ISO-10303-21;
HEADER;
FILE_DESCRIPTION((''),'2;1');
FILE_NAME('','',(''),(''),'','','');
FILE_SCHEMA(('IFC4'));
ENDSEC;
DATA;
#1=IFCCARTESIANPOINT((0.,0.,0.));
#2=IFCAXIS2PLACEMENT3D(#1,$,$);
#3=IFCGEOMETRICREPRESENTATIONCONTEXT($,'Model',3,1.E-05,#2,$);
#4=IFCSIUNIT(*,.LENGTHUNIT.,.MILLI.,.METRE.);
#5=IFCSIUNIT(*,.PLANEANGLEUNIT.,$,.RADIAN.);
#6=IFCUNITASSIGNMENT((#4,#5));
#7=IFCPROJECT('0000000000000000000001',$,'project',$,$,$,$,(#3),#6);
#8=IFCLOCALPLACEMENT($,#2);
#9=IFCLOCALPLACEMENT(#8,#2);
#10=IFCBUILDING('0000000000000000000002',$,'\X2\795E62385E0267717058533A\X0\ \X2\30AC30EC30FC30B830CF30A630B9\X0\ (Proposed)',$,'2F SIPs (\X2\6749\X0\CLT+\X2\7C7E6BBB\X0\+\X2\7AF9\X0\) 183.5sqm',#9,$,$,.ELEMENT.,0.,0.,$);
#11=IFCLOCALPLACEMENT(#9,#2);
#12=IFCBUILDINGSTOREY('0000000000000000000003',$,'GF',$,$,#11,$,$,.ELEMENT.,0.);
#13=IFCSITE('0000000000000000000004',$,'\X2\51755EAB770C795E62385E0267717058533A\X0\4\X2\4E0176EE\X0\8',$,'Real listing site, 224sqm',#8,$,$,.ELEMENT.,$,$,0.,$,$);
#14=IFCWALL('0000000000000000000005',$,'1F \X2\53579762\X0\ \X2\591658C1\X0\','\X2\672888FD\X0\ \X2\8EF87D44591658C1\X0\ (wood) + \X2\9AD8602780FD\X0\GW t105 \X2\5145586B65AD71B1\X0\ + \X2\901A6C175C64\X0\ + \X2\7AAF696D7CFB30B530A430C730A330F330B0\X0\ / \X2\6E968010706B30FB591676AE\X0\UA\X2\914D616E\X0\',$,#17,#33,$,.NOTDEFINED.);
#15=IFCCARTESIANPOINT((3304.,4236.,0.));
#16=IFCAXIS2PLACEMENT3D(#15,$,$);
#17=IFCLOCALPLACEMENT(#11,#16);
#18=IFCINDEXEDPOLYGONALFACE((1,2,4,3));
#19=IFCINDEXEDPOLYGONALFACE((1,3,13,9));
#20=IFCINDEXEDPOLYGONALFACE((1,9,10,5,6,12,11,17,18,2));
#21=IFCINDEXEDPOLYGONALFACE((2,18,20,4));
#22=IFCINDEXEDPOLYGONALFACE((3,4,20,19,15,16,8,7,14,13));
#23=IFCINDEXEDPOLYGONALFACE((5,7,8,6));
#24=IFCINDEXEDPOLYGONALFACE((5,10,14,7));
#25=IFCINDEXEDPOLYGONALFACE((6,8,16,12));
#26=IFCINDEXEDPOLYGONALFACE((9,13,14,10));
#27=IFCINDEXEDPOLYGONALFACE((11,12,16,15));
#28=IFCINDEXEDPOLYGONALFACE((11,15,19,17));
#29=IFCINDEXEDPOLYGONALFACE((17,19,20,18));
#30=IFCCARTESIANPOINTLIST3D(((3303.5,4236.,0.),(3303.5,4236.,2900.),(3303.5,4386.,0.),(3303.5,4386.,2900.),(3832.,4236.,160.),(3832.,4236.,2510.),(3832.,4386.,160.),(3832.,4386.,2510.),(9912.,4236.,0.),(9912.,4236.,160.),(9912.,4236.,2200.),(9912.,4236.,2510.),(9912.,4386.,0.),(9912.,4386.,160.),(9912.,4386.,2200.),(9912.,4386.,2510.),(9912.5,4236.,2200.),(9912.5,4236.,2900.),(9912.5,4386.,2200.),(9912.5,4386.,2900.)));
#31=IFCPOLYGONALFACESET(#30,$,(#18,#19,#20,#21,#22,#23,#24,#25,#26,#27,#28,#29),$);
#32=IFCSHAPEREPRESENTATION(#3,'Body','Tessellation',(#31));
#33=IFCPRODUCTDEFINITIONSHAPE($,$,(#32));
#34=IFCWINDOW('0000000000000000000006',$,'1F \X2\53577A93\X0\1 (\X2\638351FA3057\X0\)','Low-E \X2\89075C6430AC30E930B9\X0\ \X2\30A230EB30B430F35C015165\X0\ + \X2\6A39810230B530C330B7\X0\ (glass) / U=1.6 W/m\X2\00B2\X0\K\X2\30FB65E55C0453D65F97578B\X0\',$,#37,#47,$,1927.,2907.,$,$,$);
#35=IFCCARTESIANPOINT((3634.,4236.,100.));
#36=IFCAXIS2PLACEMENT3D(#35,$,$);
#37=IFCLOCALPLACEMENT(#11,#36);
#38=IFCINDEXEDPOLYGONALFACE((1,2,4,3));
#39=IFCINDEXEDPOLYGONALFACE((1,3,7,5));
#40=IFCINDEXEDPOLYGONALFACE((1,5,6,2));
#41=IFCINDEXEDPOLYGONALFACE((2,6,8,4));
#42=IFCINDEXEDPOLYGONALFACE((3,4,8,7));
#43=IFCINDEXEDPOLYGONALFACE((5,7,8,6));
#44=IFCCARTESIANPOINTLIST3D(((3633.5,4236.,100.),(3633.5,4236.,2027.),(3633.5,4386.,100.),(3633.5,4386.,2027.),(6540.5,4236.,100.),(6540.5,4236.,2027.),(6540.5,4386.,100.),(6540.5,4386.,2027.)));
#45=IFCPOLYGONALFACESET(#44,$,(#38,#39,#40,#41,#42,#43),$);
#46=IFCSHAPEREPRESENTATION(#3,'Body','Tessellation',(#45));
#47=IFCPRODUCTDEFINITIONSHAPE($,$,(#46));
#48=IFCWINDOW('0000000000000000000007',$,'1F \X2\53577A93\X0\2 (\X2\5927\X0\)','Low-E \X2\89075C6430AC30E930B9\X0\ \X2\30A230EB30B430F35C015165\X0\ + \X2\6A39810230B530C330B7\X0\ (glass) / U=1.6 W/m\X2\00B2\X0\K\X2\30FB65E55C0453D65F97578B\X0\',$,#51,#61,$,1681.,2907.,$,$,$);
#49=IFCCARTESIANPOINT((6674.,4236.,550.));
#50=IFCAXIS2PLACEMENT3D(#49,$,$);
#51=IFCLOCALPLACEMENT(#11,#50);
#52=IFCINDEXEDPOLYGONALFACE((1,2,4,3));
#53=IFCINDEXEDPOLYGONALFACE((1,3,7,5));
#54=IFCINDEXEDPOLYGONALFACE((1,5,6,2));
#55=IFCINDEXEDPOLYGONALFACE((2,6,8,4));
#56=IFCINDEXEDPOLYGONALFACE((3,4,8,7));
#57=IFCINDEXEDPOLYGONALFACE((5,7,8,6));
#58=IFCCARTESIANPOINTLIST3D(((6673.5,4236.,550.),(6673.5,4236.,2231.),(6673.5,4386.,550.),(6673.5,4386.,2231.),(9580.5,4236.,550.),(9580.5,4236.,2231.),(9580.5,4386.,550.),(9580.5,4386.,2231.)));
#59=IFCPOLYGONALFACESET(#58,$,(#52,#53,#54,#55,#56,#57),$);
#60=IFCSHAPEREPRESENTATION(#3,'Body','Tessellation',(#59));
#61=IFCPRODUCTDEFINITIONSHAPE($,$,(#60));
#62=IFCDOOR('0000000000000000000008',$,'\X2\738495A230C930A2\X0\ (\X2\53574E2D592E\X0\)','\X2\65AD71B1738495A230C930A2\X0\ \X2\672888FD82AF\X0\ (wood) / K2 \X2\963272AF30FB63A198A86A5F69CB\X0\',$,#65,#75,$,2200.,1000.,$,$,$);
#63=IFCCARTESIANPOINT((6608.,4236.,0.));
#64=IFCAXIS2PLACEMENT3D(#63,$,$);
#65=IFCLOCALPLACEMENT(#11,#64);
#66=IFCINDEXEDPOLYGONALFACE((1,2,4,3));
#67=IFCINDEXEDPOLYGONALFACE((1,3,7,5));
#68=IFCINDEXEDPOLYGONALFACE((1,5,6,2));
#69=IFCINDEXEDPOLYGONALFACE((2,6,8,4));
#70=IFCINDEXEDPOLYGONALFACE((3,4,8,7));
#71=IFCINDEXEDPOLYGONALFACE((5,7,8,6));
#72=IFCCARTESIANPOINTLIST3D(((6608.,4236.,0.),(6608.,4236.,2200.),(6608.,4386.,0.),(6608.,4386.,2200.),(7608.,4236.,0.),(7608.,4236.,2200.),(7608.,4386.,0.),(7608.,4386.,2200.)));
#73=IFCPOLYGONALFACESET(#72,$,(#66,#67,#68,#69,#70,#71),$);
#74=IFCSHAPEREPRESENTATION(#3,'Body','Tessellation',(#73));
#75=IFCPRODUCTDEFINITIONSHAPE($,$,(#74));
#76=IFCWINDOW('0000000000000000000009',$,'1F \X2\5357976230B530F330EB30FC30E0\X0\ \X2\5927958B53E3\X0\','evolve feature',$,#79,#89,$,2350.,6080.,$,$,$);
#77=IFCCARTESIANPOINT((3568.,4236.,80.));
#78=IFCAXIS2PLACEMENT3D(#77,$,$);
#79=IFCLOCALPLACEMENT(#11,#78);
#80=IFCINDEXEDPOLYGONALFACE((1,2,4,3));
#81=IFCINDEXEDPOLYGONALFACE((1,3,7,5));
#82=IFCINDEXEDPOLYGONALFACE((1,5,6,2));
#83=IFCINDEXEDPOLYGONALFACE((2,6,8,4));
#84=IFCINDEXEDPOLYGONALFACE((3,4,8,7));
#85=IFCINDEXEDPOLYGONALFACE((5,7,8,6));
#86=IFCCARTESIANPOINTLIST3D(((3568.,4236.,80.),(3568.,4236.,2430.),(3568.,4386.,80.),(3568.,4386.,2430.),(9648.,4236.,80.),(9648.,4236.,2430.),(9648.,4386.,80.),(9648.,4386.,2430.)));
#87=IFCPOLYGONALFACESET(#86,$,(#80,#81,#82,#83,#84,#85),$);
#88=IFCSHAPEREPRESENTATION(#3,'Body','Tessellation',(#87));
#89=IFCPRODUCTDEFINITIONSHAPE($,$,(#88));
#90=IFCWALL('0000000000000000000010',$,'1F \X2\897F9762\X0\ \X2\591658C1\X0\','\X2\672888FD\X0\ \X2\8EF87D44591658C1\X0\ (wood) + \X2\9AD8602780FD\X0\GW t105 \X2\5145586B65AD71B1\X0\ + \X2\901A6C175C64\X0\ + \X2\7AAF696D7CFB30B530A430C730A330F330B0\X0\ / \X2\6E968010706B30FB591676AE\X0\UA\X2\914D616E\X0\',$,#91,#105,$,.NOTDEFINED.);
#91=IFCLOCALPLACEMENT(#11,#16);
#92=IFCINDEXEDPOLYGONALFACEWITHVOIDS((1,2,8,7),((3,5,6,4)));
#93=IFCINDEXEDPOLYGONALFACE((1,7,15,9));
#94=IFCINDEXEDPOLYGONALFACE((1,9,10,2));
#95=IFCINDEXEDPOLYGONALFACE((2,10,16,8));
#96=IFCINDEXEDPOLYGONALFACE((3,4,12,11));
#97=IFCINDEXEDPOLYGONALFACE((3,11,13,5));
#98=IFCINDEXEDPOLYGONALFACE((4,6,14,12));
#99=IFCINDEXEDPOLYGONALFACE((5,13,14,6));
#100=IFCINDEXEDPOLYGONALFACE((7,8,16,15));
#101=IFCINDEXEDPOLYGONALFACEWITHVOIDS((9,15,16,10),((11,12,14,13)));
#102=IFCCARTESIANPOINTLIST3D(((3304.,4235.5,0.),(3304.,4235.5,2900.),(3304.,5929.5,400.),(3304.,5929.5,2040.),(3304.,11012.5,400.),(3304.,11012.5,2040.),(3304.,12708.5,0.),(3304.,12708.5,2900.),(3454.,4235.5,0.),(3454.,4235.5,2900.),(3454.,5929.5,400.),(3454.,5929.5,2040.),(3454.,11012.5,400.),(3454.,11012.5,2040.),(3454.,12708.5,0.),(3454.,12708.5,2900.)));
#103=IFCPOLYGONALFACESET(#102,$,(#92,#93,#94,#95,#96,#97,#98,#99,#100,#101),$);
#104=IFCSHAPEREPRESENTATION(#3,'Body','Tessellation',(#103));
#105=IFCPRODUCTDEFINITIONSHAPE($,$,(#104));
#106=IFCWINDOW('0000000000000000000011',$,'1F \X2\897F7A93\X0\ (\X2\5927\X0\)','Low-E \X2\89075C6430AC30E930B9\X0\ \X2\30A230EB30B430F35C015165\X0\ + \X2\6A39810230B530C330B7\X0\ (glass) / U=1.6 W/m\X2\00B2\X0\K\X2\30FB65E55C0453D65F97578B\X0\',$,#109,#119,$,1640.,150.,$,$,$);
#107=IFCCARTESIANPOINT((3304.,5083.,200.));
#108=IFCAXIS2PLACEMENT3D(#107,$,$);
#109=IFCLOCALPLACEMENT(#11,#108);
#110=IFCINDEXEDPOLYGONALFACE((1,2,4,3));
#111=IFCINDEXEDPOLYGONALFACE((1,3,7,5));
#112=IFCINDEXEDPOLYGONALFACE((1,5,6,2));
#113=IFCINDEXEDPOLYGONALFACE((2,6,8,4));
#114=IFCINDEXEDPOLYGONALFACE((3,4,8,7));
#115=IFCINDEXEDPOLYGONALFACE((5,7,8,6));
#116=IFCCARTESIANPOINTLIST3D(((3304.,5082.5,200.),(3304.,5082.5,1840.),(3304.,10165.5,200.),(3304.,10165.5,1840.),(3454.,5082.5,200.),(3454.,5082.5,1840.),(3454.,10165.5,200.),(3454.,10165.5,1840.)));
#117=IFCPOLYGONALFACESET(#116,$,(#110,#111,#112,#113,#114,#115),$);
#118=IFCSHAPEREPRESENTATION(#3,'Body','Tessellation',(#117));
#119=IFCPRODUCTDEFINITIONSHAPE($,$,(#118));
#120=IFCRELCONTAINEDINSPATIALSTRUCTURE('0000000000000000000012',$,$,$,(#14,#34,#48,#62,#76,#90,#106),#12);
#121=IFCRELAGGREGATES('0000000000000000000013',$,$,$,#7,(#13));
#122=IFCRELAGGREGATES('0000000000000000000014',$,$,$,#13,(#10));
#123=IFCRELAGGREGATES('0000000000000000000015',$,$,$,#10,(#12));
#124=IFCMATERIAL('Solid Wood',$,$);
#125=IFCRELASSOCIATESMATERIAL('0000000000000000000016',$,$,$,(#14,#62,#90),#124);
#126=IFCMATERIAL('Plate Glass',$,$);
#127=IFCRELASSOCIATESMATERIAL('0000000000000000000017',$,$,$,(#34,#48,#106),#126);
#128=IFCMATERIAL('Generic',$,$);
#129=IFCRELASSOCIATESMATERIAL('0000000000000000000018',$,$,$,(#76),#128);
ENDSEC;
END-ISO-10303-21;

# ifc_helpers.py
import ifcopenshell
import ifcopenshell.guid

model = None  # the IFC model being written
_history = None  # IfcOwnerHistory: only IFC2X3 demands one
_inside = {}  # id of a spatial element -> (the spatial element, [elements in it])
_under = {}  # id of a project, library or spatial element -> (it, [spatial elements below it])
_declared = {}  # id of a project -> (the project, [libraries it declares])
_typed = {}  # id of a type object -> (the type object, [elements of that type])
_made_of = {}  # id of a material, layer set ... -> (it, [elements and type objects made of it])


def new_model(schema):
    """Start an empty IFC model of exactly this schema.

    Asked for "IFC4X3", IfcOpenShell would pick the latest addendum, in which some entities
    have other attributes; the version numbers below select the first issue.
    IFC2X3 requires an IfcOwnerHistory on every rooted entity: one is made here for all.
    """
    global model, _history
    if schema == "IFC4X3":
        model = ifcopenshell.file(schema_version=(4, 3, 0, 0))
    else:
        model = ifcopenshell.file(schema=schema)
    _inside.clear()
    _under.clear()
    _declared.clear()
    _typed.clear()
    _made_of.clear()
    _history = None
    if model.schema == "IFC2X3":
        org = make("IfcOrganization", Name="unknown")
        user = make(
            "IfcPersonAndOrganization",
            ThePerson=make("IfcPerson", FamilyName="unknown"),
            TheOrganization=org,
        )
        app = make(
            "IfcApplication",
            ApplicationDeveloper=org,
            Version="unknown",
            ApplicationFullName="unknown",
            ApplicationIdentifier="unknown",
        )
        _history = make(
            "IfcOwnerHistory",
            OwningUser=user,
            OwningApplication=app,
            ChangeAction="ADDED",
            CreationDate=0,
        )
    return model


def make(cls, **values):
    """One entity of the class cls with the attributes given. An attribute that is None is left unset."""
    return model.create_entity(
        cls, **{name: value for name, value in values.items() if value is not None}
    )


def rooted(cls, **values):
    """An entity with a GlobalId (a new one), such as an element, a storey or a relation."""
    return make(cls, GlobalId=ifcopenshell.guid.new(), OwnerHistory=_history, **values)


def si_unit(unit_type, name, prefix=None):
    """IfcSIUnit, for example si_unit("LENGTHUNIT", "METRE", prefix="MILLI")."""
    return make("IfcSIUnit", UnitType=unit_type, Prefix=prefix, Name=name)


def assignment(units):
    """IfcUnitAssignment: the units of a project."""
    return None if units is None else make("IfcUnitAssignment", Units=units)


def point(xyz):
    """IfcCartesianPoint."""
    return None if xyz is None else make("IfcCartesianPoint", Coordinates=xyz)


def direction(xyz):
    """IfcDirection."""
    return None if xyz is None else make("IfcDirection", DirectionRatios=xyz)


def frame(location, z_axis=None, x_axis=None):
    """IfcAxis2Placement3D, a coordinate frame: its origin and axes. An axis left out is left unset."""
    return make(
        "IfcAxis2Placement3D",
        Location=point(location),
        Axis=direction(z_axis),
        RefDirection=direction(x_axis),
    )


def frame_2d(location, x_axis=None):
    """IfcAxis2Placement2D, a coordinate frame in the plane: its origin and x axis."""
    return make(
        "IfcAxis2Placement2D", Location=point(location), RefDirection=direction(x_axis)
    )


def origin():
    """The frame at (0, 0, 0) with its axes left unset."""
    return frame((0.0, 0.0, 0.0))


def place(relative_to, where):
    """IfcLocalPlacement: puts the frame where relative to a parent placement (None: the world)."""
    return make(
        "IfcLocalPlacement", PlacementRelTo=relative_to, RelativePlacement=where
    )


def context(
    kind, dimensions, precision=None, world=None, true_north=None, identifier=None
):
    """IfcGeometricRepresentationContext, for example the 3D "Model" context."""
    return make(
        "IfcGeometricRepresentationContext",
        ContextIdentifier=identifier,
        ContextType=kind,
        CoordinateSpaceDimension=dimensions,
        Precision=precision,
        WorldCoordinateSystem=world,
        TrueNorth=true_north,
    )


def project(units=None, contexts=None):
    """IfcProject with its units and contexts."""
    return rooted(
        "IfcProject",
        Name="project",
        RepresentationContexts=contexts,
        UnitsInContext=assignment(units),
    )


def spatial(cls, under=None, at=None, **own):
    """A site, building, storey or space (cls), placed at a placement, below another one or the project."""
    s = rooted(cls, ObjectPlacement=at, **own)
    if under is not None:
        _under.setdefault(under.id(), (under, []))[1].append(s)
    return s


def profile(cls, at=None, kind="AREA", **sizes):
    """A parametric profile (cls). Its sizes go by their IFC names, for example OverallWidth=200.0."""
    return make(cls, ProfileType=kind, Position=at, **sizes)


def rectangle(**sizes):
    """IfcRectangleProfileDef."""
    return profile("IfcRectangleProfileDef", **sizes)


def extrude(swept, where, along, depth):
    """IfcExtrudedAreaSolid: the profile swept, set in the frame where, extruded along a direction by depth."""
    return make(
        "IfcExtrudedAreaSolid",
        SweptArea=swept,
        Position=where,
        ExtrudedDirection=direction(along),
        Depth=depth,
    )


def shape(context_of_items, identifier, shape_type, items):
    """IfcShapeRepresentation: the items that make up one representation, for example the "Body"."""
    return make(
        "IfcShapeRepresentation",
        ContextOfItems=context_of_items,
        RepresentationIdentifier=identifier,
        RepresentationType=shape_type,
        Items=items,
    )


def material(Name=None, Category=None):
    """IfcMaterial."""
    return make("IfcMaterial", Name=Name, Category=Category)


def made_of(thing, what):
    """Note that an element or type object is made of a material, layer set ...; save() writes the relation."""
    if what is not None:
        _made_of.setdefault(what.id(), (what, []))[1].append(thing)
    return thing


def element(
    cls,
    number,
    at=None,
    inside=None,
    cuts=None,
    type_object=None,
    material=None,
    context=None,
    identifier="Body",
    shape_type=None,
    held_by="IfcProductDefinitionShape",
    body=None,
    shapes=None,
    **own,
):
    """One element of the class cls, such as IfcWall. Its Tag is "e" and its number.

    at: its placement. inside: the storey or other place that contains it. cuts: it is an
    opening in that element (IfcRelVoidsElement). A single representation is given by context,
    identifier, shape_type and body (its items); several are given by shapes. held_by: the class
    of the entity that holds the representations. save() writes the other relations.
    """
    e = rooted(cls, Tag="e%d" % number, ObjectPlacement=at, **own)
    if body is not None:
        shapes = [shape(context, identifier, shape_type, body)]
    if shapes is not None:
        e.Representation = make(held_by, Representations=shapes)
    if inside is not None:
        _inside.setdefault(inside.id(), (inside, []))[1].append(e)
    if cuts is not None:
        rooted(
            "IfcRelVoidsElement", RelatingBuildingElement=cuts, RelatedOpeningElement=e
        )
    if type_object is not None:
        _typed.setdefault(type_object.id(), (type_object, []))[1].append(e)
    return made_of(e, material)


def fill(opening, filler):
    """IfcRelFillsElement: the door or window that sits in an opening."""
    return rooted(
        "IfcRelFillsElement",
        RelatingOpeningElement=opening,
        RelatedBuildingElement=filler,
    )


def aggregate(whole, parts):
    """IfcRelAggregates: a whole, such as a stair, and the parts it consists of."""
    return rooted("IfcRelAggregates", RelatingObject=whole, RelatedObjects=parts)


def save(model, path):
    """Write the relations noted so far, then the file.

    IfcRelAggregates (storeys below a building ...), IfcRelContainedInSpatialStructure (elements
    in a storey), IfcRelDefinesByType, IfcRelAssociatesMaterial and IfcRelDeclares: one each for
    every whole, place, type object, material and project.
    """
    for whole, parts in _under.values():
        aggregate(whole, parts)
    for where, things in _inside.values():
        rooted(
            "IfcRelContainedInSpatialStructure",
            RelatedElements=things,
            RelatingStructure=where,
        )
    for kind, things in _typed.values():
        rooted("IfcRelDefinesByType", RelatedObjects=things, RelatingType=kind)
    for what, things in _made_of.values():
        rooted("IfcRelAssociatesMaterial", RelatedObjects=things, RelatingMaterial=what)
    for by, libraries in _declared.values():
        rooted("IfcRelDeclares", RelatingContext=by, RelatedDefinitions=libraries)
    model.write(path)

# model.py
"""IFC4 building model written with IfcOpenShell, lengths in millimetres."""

from ifc_helpers import new_model, si_unit, frame, frame_2d, origin, place, context, project, spatial, rectangle, extrude, material, element, fill, save


model = new_model("IFC4")

# Units and contexts
model_context = context("Model", 3, precision=1e-05, world=origin())
ifc_project = project(units=[si_unit("LENGTHUNIT", "METRE", prefix="MILLI"), si_unit("PLANEANGLEUNIT", "RADIAN")], contexts=[model_context])

# Site, building, storey
site_placement = place(None, origin())
site = spatial("IfcSite", under=ifc_project, at=site_placement, Name="兵庫県神戸市東灘区4丁目8", ObjectType="Real listing site, 224sqm", CompositionType="ELEMENT", RefElevation=0.0)
building_placement = place(site_placement, origin())
building = spatial("IfcBuilding", under=site, at=building_placement, Name="神戸市東灘区 ガレージハウス (Proposed)", ObjectType="2F SIPs (杉CLT+籾殻+竹) 183.5sqm", CompositionType="ELEMENT", ElevationOfRefHeight=0.0, ElevationOfTerrain=0.0)
storey_placement = place(building_placement, origin())
storey = spatial("IfcBuildingStorey", under=building, at=storey_placement, Name="GF", CompositionType="ELEMENT", Elevation=0.0)

# Shared definitions
ifc_material_1 = material(Name="Solid Wood")
ifc_material_2 = material(Name="Generic")

# Wall, openings, windows, door
wall_1_placement = place(storey_placement, frame((3304.0, 4236.0, 0.0)))
wall_1 = element("IfcWall", 1, at=wall_1_placement, inside=storey, material=ifc_material_1, Name="1F 南面 外壁", Description="木製 軸組外壁 (wood) + 高性能GW t105 充填断熱 + 通気層 + 窯業系サイディング / 準耐火・外皮UA配慮", PredefinedType="NOTDEFINED", context=model_context, shape_type="SweptSolid", body=[
    extrude(rectangle(XDim=6609.0, YDim=150.0, at=frame_2d((3304.0, 75.0))), frame((3304.0, 4236.0, 0.0)), (0.0, 0.0, 1.0), 2900.0),
])
opening_1_placement = place(storey_placement, frame((3634.0, 4236.0, 100.0)))
opening_1 = element("IfcOpeningElement", 2, at=opening_1_placement, cuts=wall_1, PredefinedType="NOTDEFINED", context=model_context, shape_type="SweptSolid", body=[
    extrude(rectangle(XDim=2907.0, YDim=150.0, at=frame_2d((1453.0, 75.0))), frame((3634.0, 4236.0, 100.0)), (0.0, 0.0, 1.0), 1927.0),
])
opening_2_placement = place(storey_placement, frame((6674.0, 4236.0, 550.0)))
opening_2 = element("IfcOpeningElement", 3, at=opening_2_placement, cuts=wall_1, PredefinedType="NOTDEFINED", context=model_context, shape_type="SweptSolid", body=[
    extrude(rectangle(XDim=2907.0, YDim=150.0, at=frame_2d((1453.0, 75.0))), frame((6674.0, 4236.0, 550.0)), (0.0, 0.0, 1.0), 1681.0),
])
opening_3_placement = place(storey_placement, frame((6608.0, 4236.0, 0.0)))
opening_3 = element("IfcOpeningElement", 4, at=opening_3_placement, cuts=wall_1, PredefinedType="NOTDEFINED", context=model_context, shape_type="SweptSolid", body=[
    extrude(rectangle(XDim=1000.0, YDim=150.0, at=frame_2d((500.0, 75.0))), frame((6608.0, 4236.0, 0.0)), (0.0, 0.0, 1.0), 2200.0),
])
opening_4_placement = place(storey_placement, frame((3568.0, 4236.0, 80.0)))
opening_4 = element("IfcOpeningElement", 5, at=opening_4_placement, cuts=wall_1, PredefinedType="NOTDEFINED", context=model_context, shape_type="SweptSolid", body=[
    extrude(rectangle(XDim=6080.0, YDim=150.0, at=frame_2d((3040.0, 75.0))), frame((3568.0, 4236.0, 80.0)), (0.0, 0.0, 1.0), 2350.0),
])
ifc_material_3 = material(Name="Plate Glass")
window_1_placement = place(storey_placement, frame((3634.0, 4236.0, 100.0)))
window_1 = element("IfcWindow", 6, at=window_1_placement, inside=storey, material=ifc_material_3, Name="1F 南窓1 (掃出し)", Description="Low-E 複層ガラス アルゴン封入 + 樹脂サッシ (glass) / U=1.6 W/m²K・日射取得型", OverallHeight=1927.0, OverallWidth=2907.0, context=model_context, shape_type="SweptSolid", body=[
    extrude(rectangle(XDim=2907.0, YDim=150.0, at=frame_2d((1453.0, 75.0))), frame((3634.0, 4236.0, 100.0)), (0.0, 0.0, 1.0), 1927.0),
])
fill(opening_1, window_1)
window_2_placement = place(storey_placement, frame((6674.0, 4236.0, 550.0)))
window_2 = element("IfcWindow", 7, at=window_2_placement, inside=storey, material=ifc_material_3, Name="1F 南窓2 (大)", Description="Low-E 複層ガラス アルゴン封入 + 樹脂サッシ (glass) / U=1.6 W/m²K・日射取得型", OverallHeight=1681.0, OverallWidth=2907.0, context=model_context, shape_type="SweptSolid", body=[
    extrude(rectangle(XDim=2907.0, YDim=150.0, at=frame_2d((1453.0, 75.0))), frame((6674.0, 4236.0, 550.0)), (0.0, 0.0, 1.0), 1681.0),
])
fill(opening_2, window_2)
door_placement = place(storey_placement, frame((6608.0, 4236.0, 0.0)))
door = element("IfcDoor", 8, at=door_placement, inside=storey, material=ifc_material_1, Name="玄関ドア (南中央)", Description="断熱玄関ドア 木製芯 (wood) / K2 防犯・採風機構", OverallHeight=2200.0, OverallWidth=1000.0, context=model_context, shape_type="SweptSolid", body=[
    extrude(rectangle(XDim=1000.0, YDim=150.0, at=frame_2d((500.0, 75.0))), frame((6608.0, 4236.0, 0.0)), (0.0, 0.0, 1.0), 2200.0),
])
fill(opening_3, door)
window_3_placement = place(storey_placement, frame((3568.0, 4236.0, 80.0)))
window_3 = element("IfcWindow", 9, at=window_3_placement, inside=storey, material=ifc_material_2, Name="1F 南面サンルーム 大開口", Description="evolve feature", OverallHeight=2350.0, OverallWidth=6080.0, context=model_context, shape_type="SweptSolid", body=[
    extrude(rectangle(XDim=6080.0, YDim=150.0, at=frame_2d((3040.0, 75.0))), frame((3568.0, 4236.0, 80.0)), (0.0, 0.0, 1.0), 2350.0),
])
fill(opening_4, window_3)

# Wall, opening, window
wall_2_placement = place(storey_placement, frame((3304.0, 4236.0, 0.0)))
wall_2 = element("IfcWall", 10, at=wall_2_placement, inside=storey, material=ifc_material_1, Name="1F 西面 外壁", Description="木製 軸組外壁 (wood) + 高性能GW t105 充填断熱 + 通気層 + 窯業系サイディング / 準耐火・外皮UA配慮", PredefinedType="NOTDEFINED", context=model_context, shape_type="SweptSolid", body=[
    extrude(rectangle(XDim=150.0, YDim=8473.0, at=frame_2d((75.0, 4236.0))), frame((3304.0, 4236.0, 0.0)), (0.0, 0.0, 1.0), 2900.0),
])
opening_5_placement = place(storey_placement, frame((3304.0, 5083.0, 200.0)))
opening_5 = element("IfcOpeningElement", 11, at=opening_5_placement, cuts=wall_2, PredefinedType="NOTDEFINED", context=model_context, shape_type="SweptSolid", body=[
    extrude(rectangle(XDim=150.0, YDim=5083.0, at=frame_2d((75.0, 2541.0))), frame((3304.0, 5083.0, 200.0)), (0.0, 0.0, 1.0), 1640.0),
])
window_4_placement = place(storey_placement, frame((3304.0, 5083.0, 200.0)))
window_4 = element("IfcWindow", 12, at=window_4_placement, inside=storey, material=ifc_material_3, Name="1F 西窓 (大)", Description="Low-E 複層ガラス アルゴン封入 + 樹脂サッシ (glass) / U=1.6 W/m²K・日射取得型", OverallHeight=1640.0, OverallWidth=150.0, context=model_context, shape_type="SweptSolid", body=[
    extrude(rectangle(XDim=150.0, YDim=5083.0, at=frame_2d((75.0, 2541.0))), frame((3304.0, 5083.0, 200.0)), (0.0, 0.0, 1.0), 1640.0),
])
fill(opening_5, window_4)

save(model, "model.ifc")
